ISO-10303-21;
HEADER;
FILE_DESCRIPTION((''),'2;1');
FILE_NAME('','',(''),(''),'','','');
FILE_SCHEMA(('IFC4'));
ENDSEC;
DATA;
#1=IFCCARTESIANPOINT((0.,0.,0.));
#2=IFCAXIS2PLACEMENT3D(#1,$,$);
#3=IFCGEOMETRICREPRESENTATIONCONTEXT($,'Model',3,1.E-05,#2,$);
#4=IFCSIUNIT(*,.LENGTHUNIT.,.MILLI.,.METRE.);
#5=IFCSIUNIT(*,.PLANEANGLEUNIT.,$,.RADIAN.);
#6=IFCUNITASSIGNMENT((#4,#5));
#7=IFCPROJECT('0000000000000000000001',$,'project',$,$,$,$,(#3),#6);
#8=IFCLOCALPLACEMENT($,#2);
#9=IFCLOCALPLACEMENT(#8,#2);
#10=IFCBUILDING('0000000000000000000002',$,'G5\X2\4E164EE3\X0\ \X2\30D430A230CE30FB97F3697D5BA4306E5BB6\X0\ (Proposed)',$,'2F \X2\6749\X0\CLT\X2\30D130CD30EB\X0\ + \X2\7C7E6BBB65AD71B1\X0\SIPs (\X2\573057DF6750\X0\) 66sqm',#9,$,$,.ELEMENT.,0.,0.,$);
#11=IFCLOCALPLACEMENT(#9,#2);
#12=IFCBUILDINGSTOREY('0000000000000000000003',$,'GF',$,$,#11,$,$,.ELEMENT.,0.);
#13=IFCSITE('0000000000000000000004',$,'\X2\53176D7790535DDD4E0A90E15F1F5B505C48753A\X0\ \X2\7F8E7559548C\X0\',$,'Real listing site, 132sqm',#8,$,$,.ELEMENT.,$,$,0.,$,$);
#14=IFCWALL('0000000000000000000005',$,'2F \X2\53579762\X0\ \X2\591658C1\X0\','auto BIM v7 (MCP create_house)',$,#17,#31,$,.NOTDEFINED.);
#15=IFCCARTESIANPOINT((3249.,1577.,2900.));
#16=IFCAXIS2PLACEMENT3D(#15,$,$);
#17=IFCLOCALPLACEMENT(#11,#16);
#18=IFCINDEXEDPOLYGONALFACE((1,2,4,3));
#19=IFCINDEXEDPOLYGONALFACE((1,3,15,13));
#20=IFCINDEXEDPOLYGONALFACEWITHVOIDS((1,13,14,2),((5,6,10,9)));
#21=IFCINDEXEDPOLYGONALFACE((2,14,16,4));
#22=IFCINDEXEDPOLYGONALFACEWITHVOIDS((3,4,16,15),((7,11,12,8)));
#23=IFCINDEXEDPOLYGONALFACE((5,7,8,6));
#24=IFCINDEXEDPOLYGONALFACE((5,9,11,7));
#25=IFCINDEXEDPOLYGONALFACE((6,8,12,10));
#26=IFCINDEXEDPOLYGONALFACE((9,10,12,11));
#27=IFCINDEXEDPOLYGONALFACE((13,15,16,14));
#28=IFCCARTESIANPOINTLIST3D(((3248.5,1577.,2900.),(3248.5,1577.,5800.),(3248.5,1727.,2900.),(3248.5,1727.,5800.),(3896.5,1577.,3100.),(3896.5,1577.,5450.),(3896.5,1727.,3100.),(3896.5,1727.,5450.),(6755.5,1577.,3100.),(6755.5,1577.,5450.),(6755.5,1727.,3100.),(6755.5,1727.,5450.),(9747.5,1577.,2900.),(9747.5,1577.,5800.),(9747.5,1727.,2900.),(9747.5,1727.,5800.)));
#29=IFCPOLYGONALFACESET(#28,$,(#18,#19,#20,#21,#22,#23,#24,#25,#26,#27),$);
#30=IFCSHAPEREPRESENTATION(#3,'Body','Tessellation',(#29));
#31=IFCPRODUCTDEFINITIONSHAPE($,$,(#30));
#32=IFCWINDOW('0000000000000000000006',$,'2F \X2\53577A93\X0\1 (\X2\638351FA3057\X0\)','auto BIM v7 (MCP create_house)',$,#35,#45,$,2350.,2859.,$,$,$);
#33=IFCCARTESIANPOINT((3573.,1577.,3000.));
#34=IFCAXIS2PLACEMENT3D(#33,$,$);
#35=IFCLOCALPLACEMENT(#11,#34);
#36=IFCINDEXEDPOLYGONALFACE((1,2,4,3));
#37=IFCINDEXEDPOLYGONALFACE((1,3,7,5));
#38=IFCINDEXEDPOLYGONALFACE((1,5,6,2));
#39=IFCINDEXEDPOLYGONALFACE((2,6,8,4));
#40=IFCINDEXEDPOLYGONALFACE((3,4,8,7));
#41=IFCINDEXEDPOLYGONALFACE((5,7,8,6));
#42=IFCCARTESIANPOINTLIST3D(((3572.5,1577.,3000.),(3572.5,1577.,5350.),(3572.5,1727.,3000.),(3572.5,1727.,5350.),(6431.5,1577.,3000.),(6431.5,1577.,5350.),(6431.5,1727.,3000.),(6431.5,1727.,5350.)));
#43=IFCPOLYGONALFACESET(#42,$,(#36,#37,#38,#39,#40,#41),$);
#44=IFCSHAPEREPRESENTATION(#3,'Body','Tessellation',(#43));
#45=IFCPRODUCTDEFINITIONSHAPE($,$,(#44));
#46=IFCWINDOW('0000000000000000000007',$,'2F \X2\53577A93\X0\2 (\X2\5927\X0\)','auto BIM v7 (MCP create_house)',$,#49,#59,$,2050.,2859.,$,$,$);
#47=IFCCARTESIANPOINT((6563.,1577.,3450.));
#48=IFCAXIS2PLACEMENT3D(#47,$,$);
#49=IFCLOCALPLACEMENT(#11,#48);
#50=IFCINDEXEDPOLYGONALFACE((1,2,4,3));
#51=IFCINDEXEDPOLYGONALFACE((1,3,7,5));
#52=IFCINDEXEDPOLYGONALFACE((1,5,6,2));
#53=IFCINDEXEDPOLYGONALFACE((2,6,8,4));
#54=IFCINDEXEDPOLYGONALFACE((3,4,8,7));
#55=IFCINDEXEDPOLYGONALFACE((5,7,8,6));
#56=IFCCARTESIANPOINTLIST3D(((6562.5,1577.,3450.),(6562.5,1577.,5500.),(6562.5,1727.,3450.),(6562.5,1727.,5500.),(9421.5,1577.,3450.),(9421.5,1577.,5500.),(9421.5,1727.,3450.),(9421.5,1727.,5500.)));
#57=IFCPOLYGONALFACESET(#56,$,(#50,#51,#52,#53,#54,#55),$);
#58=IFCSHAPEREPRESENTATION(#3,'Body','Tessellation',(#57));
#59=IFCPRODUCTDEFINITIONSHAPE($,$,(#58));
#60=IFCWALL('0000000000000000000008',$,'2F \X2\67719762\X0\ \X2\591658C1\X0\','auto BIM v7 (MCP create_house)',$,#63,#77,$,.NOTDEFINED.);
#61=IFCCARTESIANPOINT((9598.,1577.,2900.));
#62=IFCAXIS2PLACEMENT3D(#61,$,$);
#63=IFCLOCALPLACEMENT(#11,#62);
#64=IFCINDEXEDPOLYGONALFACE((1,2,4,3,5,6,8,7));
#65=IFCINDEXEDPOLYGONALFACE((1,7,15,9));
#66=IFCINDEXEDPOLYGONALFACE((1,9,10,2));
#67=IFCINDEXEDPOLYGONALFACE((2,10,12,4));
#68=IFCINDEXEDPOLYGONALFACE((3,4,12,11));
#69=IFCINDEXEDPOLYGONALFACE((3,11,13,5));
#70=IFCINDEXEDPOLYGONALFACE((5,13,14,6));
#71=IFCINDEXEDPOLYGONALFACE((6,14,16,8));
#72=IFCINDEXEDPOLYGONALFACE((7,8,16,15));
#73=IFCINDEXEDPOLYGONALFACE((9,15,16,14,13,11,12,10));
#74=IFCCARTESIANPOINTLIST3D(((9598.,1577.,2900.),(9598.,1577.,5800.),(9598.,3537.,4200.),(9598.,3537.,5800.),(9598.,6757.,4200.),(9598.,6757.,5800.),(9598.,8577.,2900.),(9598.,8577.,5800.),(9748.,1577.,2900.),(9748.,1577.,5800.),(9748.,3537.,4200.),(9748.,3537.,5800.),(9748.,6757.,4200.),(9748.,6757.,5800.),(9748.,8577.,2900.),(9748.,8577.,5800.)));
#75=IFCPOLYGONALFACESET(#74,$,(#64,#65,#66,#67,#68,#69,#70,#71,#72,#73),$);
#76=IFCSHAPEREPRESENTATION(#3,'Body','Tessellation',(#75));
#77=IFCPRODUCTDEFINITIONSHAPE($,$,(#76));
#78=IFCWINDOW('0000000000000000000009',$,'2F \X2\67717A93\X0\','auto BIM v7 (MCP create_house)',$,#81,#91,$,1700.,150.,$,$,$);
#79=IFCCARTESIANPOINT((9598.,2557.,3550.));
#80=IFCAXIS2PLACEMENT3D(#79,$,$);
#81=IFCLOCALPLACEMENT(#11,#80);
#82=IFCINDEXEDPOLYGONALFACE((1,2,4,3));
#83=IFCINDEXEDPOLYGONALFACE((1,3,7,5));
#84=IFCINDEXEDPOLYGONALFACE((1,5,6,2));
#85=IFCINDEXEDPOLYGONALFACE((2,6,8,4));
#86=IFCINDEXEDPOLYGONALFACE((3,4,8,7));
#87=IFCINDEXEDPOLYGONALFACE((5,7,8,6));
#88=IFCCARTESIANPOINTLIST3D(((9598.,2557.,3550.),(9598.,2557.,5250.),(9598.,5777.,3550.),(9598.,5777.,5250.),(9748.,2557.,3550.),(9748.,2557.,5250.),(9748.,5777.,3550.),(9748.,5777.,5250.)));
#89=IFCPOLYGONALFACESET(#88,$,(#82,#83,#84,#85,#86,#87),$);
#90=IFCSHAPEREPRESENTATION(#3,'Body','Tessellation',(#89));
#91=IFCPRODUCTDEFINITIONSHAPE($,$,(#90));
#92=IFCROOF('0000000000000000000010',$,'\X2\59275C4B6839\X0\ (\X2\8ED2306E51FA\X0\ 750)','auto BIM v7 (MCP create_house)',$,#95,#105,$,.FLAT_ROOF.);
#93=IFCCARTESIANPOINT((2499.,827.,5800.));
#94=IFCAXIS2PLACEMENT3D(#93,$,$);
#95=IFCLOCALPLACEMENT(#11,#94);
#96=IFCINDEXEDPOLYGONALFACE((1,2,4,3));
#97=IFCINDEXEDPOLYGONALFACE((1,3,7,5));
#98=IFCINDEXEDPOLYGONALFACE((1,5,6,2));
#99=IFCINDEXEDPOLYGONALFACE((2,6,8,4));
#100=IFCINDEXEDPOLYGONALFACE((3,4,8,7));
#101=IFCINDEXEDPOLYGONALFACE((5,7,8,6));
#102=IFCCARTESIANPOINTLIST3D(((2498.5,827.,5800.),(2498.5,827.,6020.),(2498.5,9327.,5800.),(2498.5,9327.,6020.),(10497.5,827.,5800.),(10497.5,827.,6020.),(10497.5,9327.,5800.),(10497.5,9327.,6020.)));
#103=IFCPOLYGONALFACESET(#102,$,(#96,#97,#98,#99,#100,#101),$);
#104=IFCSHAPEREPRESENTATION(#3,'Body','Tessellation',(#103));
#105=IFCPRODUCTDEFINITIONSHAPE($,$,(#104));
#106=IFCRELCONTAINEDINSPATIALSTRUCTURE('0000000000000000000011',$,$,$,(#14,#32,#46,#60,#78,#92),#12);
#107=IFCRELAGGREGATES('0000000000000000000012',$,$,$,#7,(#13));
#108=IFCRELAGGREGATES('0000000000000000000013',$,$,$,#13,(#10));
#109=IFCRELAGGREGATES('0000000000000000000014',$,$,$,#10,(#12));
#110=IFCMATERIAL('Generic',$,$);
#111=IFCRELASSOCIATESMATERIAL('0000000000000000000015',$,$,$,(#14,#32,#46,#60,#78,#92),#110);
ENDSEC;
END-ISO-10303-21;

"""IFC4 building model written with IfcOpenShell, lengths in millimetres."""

from ifc_helpers import new_model, si_unit, frame, frame_2d, origin, place, context, project, spatial, rectangle, extrude, material, element, fill, save


model = new_model("IFC4")

# Units and contexts
model_context = context("Model", 3, precision=1e-05, world=origin())
ifc_project = project(units=[si_unit("LENGTHUNIT", "METRE", prefix="MILLI"), si_unit("PLANEANGLEUNIT", "RADIAN")], contexts=[model_context])

# Site, building, storey
site_placement = place(None, origin())
site = spatial("IfcSite", under=ifc_project, at=site_placement, Name="北海道川上郡弟子屈町 美留和", ObjectType="Real listing site, 132sqm", CompositionType="ELEMENT", RefElevation=0.0)
building_placement = place(site_placement, origin())
building = spatial("IfcBuilding", under=site, at=building_placement, Name="G5世代 ピアノ・音楽室の家 (Proposed)", ObjectType="2F 杉CLTパネル + 籾殻断熱SIPs (地域材) 66sqm", CompositionType="ELEMENT", ElevationOfRefHeight=0.0, ElevationOfTerrain=0.0)
storey_placement = place(building_placement, origin())
storey = spatial("IfcBuildingStorey", under=building, at=storey_placement, Name="GF", CompositionType="ELEMENT", Elevation=0.0)

# Shared definitions
ifc_material = material(Name="Generic")

# Wall, openings, windows
wall_1_placement = place(storey_placement, frame((3249.0, 1577.0, 2900.0)))
wall_1 = element("IfcWall", 1, at=wall_1_placement, inside=storey, material=ifc_material, Name="2F 南面 外壁", Description="auto BIM v7 (MCP create_house)", PredefinedType="NOTDEFINED", context=model_context, shape_type="SweptSolid", body=[
    extrude(rectangle(XDim=6499.0, YDim=150.0, at=frame_2d((3249.0, 75.0))), frame((3249.0, 1577.0, 2900.0)), (0.0, 0.0, 1.0), 2900.0),
])
opening_1_placement = place(storey_placement, frame((3573.0, 1577.0, 3000.0)))
opening_1 = element("IfcOpeningElement", 2, at=opening_1_placement, cuts=wall_1, PredefinedType="NOTDEFINED", context=model_context, shape_type="SweptSolid", body=[
    extrude(rectangle(XDim=2859.0, YDim=150.0, at=frame_2d((1429.0, 75.0))), frame((3573.0, 1577.0, 3000.0)), (0.0, 0.0, 1.0), 2350.0),
])
opening_2_placement = place(storey_placement, frame((6563.0, 1577.0, 3450.0)))
opening_2 = element("IfcOpeningElement", 3, at=opening_2_placement, cuts=wall_1, PredefinedType="NOTDEFINED", context=model_context, shape_type="SweptSolid", body=[
    extrude(rectangle(XDim=2859.0, YDim=150.0, at=frame_2d((1429.0, 75.0))), frame((6563.0, 1577.0, 3450.0)), (0.0, 0.0, 1.0), 2050.0),
])
window_1_placement = place(storey_placement, frame((3573.0, 1577.0, 3000.0)))
window_1 = element("IfcWindow", 4, at=window_1_placement, inside=storey, material=ifc_material, Name="2F 南窓1 (掃出し)", Description="auto BIM v7 (MCP create_house)", OverallHeight=2350.0, OverallWidth=2859.0, context=model_context, shape_type="SweptSolid", body=[
    extrude(rectangle(XDim=2859.0, YDim=150.0, at=frame_2d((1429.0, 75.0))), frame((3573.0, 1577.0, 3000.0)), (0.0, 0.0, 1.0), 2350.0),
])
fill(opening_1, window_1)
window_2_placement = place(storey_placement, frame((6563.0, 1577.0, 3450.0)))
window_2 = element("IfcWindow", 5, at=window_2_placement, inside=storey, material=ifc_material, Name="2F 南窓2 (大)", Description="auto BIM v7 (MCP create_house)", OverallHeight=2050.0, OverallWidth=2859.0, context=model_context, shape_type="SweptSolid", body=[
    extrude(rectangle(XDim=2859.0, YDim=150.0, at=frame_2d((1429.0, 75.0))), frame((6563.0, 1577.0, 3450.0)), (0.0, 0.0, 1.0), 2050.0),
])
fill(opening_2, window_2)

# Wall, opening, window
wall_2_placement = place(storey_placement, frame((9598.0, 1577.0, 2900.0)))
wall_2 = element("IfcWall", 6, at=wall_2_placement, inside=storey, material=ifc_material, Name="2F 東面 外壁", Description="auto BIM v7 (MCP create_house)", PredefinedType="NOTDEFINED", context=model_context, shape_type="SweptSolid", body=[
    extrude(rectangle(XDim=150.0, YDim=7000.0, at=frame_2d((75.0, 3500.0))), frame((9598.0, 1577.0, 2900.0)), (0.0, 0.0, 1.0), 2900.0),
])
opening_3_placement = place(storey_placement, frame((9598.0, 2557.0, 3550.0)))
opening_3 = element("IfcOpeningElement", 7, at=opening_3_placement, cuts=wall_2, PredefinedType="NOTDEFINED", context=model_context, shape_type="SweptSolid", body=[
    extrude(rectangle(XDim=150.0, YDim=3220.0, at=frame_2d((75.0, 1610.0))), frame((9598.0, 2557.0, 3550.0)), (0.0, 0.0, 1.0), 1700.0),
])
window_3_placement = place(storey_placement, frame((9598.0, 2557.0, 3550.0)))
window_3 = element("IfcWindow", 8, at=window_3_placement, inside=storey, material=ifc_material, Name="2F 東窓", Description="auto BIM v7 (MCP create_house)", OverallHeight=1700.0, OverallWidth=150.0, context=model_context, shape_type="SweptSolid", body=[
    extrude(rectangle(XDim=150.0, YDim=3220.0, at=frame_2d((75.0, 1610.0))), frame((9598.0, 2557.0, 3550.0)), (0.0, 0.0, 1.0), 1700.0),
])
fill(opening_3, window_3)

# Roof
roof_placement = place(storey_placement, frame((2499.0, 827.0, 5800.0)))
element("IfcRoof", 9, at=roof_placement, inside=storey, material=ifc_material, Name="大屋根 (軒の出 750)", Description="auto BIM v7 (MCP create_house)", PredefinedType="FLAT_ROOF", context=model_context, shape_type="SweptSolid", body=[
    extrude(rectangle(XDim=7999.0, YDim=8500.0, at=frame_2d((3999.0, 4250.0))), frame((2499.0, 827.0, 5800.0)), (0.0, 0.0, 1.0), 220.0),
])

save(model, "model.ifc")
